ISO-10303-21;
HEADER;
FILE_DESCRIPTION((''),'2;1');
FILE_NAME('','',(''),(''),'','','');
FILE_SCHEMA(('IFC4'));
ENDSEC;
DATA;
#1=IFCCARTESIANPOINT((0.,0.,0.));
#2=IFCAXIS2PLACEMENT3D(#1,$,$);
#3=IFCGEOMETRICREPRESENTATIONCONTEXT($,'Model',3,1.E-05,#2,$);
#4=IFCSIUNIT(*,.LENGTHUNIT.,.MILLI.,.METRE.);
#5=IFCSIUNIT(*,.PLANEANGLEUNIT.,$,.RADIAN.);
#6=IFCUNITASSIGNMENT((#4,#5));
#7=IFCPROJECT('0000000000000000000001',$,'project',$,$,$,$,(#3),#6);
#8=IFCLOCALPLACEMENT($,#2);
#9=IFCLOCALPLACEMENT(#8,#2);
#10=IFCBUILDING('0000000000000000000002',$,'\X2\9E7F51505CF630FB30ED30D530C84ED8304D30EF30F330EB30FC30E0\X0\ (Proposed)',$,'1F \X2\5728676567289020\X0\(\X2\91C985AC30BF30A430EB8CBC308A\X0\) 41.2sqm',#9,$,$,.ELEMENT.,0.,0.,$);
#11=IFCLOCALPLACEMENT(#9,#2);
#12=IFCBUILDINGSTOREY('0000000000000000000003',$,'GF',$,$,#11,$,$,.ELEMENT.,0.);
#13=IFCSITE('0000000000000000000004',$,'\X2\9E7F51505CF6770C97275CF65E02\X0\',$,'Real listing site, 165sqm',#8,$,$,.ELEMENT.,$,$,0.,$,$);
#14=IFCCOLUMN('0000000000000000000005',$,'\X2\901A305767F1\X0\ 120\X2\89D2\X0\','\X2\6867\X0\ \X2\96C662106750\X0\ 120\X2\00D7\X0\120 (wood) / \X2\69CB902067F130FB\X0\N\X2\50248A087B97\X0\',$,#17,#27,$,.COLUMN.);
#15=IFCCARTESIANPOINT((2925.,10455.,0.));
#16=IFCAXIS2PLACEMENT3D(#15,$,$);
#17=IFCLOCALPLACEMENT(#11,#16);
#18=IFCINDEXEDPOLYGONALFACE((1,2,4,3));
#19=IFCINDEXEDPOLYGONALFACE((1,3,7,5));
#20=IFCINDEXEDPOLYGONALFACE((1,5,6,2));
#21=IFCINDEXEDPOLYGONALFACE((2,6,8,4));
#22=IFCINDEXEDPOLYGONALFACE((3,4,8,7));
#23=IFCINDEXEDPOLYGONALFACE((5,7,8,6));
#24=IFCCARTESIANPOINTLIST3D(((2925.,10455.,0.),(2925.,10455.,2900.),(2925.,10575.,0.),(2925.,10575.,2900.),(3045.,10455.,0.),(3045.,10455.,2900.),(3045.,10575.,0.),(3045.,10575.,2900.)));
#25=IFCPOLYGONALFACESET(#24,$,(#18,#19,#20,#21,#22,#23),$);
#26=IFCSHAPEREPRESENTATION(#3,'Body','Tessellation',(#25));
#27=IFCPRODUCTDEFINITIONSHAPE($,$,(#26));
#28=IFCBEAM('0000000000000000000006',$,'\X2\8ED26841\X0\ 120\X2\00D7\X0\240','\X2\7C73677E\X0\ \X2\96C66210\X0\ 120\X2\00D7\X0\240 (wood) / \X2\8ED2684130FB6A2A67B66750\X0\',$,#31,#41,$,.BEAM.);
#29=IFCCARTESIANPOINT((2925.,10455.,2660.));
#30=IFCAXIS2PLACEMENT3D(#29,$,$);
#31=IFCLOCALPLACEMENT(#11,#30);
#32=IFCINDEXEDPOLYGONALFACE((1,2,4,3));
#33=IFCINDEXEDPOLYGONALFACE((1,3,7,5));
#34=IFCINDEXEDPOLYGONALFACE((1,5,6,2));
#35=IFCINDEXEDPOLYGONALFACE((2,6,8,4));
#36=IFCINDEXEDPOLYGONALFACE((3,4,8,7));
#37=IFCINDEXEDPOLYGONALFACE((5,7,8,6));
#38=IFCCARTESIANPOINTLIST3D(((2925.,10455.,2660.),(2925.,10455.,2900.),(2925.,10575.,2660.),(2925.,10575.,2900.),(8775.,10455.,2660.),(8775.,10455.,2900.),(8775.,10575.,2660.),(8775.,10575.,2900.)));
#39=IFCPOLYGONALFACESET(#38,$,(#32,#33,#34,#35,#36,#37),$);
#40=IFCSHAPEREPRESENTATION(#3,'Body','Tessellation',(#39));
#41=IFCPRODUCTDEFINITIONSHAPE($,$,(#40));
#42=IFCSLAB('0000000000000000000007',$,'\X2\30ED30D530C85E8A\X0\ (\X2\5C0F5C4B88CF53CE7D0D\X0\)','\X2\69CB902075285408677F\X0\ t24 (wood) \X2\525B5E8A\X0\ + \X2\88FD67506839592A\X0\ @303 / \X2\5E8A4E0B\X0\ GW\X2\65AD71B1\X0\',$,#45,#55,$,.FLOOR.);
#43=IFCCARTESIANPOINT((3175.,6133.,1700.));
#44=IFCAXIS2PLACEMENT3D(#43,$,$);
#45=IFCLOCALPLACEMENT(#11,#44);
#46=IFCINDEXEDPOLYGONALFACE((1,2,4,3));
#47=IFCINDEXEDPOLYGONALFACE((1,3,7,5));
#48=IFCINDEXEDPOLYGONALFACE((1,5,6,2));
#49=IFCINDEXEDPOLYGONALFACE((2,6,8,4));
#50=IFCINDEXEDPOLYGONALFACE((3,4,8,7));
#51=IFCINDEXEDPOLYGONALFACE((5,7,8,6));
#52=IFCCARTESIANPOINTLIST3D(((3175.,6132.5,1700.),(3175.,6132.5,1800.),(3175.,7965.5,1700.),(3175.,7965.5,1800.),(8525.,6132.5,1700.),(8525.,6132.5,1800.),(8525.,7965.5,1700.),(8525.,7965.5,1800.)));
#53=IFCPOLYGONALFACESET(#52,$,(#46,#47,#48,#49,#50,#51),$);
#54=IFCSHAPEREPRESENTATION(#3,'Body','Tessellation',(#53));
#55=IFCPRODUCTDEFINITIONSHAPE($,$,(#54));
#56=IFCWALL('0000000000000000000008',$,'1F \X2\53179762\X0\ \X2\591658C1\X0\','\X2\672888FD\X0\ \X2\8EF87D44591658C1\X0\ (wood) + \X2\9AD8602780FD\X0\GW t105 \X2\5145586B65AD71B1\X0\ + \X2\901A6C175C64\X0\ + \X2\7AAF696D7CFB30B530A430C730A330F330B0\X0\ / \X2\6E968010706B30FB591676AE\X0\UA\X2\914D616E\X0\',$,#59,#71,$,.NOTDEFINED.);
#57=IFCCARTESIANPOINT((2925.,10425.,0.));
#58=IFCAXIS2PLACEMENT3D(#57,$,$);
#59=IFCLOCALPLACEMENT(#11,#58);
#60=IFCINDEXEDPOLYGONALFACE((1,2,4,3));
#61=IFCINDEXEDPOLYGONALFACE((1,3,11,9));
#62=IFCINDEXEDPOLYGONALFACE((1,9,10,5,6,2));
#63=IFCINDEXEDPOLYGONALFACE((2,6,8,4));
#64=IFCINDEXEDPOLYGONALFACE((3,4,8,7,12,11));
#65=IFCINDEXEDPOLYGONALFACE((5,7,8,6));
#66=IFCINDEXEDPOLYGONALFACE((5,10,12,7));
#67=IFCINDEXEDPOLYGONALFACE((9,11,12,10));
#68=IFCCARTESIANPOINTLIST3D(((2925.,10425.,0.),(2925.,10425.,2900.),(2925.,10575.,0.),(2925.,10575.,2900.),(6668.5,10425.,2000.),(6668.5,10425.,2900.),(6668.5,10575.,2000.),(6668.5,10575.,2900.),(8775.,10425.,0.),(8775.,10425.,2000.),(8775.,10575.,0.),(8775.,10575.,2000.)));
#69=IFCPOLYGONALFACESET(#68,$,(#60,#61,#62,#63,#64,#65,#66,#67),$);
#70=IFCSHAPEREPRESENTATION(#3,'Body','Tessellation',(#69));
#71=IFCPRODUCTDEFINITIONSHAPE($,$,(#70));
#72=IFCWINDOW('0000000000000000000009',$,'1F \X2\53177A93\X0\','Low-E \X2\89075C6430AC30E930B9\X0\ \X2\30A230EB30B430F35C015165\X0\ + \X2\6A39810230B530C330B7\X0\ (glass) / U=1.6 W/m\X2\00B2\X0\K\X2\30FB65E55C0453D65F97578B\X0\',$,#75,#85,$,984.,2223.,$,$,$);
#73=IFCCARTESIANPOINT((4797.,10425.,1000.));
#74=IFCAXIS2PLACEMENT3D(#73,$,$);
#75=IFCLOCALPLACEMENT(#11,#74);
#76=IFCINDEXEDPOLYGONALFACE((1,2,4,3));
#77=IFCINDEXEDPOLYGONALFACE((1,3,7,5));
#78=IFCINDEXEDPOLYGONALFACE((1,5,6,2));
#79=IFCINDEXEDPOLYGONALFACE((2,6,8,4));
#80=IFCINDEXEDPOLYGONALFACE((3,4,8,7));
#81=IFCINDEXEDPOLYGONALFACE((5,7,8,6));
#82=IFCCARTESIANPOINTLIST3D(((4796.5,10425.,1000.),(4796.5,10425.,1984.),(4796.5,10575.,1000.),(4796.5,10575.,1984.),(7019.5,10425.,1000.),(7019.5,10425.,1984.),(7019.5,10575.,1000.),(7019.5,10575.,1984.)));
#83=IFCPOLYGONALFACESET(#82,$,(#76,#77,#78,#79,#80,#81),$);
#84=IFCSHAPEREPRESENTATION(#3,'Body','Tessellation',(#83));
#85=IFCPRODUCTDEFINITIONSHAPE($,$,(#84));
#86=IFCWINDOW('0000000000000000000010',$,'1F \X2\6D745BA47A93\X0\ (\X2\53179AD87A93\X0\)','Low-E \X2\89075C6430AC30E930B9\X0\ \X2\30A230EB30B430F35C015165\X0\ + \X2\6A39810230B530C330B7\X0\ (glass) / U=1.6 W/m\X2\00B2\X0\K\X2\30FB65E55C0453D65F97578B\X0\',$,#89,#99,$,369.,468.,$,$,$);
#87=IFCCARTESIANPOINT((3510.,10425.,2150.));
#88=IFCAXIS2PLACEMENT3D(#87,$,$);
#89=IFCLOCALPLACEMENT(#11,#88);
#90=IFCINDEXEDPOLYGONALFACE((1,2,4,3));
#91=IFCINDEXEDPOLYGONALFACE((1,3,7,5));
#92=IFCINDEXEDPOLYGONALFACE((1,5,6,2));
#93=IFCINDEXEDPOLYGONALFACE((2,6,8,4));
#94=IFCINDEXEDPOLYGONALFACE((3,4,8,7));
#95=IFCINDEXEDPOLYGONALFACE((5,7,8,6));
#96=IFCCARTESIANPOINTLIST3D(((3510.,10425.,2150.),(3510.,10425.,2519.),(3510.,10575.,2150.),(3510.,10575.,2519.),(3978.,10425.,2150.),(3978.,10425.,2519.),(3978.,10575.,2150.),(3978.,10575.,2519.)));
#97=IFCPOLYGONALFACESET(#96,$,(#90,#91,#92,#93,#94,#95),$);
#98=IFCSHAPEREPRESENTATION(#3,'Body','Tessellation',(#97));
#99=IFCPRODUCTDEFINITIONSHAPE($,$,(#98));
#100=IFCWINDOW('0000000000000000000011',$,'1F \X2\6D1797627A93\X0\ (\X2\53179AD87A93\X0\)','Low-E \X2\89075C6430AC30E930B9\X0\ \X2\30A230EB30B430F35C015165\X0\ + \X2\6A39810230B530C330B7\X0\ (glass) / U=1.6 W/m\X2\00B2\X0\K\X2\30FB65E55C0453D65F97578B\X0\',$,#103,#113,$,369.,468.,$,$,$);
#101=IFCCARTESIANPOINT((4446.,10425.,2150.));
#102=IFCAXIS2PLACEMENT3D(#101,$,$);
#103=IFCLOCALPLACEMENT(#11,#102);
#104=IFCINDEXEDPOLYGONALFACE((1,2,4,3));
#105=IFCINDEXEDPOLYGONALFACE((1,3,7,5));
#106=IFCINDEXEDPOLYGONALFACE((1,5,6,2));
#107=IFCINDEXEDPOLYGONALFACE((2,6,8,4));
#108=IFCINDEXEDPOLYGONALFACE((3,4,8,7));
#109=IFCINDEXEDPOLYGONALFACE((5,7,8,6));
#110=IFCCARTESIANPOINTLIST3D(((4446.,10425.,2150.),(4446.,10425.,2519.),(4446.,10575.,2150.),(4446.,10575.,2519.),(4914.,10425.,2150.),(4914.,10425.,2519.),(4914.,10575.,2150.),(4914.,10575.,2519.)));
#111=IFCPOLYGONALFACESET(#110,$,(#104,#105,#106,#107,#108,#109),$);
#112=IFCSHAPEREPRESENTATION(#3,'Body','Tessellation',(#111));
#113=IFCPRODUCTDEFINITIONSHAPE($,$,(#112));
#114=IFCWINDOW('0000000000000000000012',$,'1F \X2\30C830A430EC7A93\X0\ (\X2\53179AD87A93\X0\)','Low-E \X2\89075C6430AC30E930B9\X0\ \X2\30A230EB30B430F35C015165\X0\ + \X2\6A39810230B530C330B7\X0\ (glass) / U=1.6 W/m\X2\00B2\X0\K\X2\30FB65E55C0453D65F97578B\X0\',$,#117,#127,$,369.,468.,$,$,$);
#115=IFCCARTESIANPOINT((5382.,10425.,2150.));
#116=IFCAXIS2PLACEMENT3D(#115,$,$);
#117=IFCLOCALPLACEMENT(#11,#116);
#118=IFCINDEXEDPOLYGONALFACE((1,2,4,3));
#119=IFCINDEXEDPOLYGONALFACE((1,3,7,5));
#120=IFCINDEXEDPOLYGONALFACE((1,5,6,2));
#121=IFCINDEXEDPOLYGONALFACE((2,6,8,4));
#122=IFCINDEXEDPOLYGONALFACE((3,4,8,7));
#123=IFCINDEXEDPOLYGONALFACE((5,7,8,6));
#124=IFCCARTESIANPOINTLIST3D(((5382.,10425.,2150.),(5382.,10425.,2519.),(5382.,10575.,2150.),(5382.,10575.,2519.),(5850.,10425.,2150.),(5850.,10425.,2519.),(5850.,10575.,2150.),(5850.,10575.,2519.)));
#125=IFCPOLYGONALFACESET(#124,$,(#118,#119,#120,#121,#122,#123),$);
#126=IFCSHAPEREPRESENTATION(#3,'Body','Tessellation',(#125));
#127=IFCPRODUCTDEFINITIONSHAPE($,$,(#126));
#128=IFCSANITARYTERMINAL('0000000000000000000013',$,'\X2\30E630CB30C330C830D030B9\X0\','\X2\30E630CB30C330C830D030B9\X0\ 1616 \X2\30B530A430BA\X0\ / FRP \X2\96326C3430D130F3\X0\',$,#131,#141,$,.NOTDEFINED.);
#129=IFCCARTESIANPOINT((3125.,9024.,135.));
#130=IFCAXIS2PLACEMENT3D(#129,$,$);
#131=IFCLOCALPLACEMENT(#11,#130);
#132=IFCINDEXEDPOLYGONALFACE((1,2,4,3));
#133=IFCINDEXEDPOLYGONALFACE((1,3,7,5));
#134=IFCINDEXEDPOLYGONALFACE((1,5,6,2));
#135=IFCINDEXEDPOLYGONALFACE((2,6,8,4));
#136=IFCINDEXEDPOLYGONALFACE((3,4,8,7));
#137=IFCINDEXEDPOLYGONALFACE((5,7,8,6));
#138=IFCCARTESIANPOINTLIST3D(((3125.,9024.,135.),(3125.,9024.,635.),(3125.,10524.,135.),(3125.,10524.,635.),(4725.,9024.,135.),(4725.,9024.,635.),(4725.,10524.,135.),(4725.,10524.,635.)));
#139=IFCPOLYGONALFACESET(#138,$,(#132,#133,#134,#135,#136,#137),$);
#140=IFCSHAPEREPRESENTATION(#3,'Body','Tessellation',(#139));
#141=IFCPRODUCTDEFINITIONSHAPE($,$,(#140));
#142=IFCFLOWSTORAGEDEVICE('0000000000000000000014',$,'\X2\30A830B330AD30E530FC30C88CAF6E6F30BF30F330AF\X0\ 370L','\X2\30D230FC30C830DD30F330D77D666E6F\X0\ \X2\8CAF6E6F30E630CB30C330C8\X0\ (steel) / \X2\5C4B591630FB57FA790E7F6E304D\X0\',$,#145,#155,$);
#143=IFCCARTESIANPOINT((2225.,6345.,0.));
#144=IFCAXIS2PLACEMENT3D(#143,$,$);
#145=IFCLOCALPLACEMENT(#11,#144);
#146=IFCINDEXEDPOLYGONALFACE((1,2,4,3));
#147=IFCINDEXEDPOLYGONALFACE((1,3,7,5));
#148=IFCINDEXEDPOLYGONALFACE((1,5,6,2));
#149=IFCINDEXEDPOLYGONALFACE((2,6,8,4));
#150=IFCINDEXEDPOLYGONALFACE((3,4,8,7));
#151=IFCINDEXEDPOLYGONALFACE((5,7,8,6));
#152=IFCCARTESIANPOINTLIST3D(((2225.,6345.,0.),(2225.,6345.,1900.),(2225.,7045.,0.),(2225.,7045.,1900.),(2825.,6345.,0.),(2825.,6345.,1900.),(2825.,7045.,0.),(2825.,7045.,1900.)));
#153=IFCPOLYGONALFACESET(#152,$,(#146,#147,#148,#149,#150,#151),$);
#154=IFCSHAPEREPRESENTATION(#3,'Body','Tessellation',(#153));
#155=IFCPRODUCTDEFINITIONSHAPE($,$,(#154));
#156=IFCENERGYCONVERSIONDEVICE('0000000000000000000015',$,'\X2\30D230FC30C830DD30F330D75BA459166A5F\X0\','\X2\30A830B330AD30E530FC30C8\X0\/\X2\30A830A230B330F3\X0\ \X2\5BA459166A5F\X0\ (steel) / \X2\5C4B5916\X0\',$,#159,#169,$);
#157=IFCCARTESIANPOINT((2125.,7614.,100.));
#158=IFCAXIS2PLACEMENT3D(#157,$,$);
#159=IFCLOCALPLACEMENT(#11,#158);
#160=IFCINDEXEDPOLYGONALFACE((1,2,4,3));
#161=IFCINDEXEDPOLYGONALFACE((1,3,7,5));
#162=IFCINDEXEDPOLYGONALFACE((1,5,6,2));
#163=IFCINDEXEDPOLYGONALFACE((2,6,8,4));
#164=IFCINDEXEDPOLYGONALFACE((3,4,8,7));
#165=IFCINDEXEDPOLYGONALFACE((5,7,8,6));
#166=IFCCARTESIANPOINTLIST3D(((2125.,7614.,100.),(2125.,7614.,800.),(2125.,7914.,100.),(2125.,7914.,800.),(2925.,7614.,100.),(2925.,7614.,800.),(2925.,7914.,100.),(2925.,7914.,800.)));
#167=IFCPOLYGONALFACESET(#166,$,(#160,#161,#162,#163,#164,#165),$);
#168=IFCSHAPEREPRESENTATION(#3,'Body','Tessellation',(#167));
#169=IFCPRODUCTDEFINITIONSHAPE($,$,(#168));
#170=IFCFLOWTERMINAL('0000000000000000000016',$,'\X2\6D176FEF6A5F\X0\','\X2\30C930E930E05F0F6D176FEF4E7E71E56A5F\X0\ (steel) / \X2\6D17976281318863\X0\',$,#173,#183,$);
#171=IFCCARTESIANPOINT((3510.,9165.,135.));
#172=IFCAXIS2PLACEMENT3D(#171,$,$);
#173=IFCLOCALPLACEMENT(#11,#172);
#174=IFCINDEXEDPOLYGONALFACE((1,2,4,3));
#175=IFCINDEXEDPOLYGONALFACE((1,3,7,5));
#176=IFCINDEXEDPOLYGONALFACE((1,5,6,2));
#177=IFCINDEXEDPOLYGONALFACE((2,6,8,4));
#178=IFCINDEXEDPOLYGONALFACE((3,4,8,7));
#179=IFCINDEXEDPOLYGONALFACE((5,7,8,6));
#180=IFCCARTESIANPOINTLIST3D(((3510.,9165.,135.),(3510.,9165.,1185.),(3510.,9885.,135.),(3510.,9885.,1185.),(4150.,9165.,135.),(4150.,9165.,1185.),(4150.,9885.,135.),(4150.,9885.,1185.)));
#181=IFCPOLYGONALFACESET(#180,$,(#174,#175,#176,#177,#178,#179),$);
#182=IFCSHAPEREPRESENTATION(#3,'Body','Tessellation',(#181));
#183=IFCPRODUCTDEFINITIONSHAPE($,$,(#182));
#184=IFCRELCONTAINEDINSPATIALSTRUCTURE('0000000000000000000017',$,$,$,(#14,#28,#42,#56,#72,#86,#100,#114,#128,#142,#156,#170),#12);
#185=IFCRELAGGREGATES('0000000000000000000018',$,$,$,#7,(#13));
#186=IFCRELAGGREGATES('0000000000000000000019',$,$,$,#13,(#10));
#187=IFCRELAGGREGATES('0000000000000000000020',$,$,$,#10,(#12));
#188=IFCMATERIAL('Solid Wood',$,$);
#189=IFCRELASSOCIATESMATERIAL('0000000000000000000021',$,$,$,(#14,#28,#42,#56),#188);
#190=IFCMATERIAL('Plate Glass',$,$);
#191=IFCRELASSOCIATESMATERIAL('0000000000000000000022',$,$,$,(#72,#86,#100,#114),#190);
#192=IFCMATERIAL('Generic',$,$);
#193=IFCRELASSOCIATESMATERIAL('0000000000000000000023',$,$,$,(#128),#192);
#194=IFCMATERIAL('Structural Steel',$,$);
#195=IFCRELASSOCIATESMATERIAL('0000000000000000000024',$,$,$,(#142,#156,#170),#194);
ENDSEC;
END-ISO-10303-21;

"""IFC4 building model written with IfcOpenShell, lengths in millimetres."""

from ifc_helpers import new_model, si_unit, frame, frame_2d, origin, place, context, project, spatial, rectangle, extrude, material, element, fill, save


model = new_model("IFC4")

# Units and contexts
model_context = context("Model", 3, precision=1e-05, world=origin())
ifc_project = project(units=[si_unit("LENGTHUNIT", "METRE", prefix="MILLI"), si_unit("PLANEANGLEUNIT", "RADIAN")], contexts=[model_context])

# Site, building, storey
site_placement = place(None, origin())
site = spatial("IfcSite", under=ifc_project, at=site_placement, Name="鹿児島県霧島市", ObjectType="Real listing site, 165sqm", CompositionType="ELEMENT", RefElevation=0.0)
building_placement = place(site_placement, origin())
building = spatial("IfcBuilding", under=site, at=building_placement, Name="鹿児島・ロフト付きワンルーム (Proposed)", ObjectType="1F 在来木造(釉薬タイル貼り) 41.2sqm", CompositionType="ELEMENT", ElevationOfRefHeight=0.0, ElevationOfTerrain=0.0)
storey_placement = place(building_placement, origin())
storey = spatial("IfcBuildingStorey", under=building, at=storey_placement, Name="GF", CompositionType="ELEMENT", Elevation=0.0)

# Column
ifc_material_1 = material(Name="Solid Wood")
column_1_placement = place(storey_placement, frame((2925.0, 10455.0, 0.0)))
element("IfcColumn", 1, at=column_1_placement, inside=storey, material=ifc_material_1, Name="通し柱 120角", Description="桧 集成材 120×120 (wood) / 構造柱・N値計算", PredefinedType="COLUMN", context=model_context, shape_type="SweptSolid", body=[
    extrude(rectangle(XDim=120.0, YDim=120.0, at=frame_2d((60.0, 60.0))), frame((2925.0, 10455.0, 0.0)), (0.0, 0.0, 1.0), 2900.0),
])

# Beam
beam_1_placement = place(storey_placement, frame((2925.0, 10455.0, 2660.0)))
element("IfcBeam", 2, at=beam_1_placement, inside=storey, material=ifc_material_1, Name="軒桁 120×240", Description="米松 集成 120×240 (wood) / 軒桁・横架材", PredefinedType="BEAM", context=model_context, shape_type="SweptSolid", body=[
    extrude(rectangle(XDim=5850.0, YDim=120.0, at=frame_2d((2925.0, 60.0))), frame((2925.0, 10455.0, 2660.0)), (0.0, 0.0, 1.0), 240.0),
])

# Slab
slab_placement = place(storey_placement, frame((3175.0, 6133.0, 1700.0)))
element("IfcSlab", 3, at=slab_placement, inside=storey, material=ifc_material_1, Name="ロフト床 (小屋裏収納)", Description="構造用合板 t24 (wood) 剛床 + 製材根太 @303 / 床下 GW断熱", PredefinedType="FLOOR", context=model_context, shape_type="SweptSolid", body=[
    extrude(rectangle(XDim=5350.0, YDim=1833.0, at=frame_2d((2675.0, 916.0))), frame((3175.0, 6133.0, 1700.0)), (0.0, 0.0, 1.0), 100.0),
])

# Wall, openings, windows
wall_1_placement = place(storey_placement, frame((2925.0, 10425.0, 0.0)))
wall_1 = element("IfcWall", 4, at=wall_1_placement, inside=storey, material=ifc_material_1, Name="1F 北面 外壁", Description="木製 軸組外壁 (wood) + 高性能GW t105 充填断熱 + 通気層 + 窯業系サイディング / 準耐火・外皮UA配慮", PredefinedType="NOTDEFINED", context=model_context, shape_type="SweptSolid", body=[
    extrude(rectangle(XDim=5850.0, YDim=150.0, at=frame_2d((2925.0, 75.0))), frame((2925.0, 10425.0, 0.0)), (0.0, 0.0, 1.0), 2900.0),
])
opening_1_placement = place(storey_placement, frame((4797.0, 10425.0, 1000.0)))
opening_1 = element("IfcOpeningElement", 5, at=opening_1_placement, cuts=wall_1, PredefinedType="NOTDEFINED", context=model_context, shape_type="SweptSolid", body=[
    extrude(rectangle(XDim=2223.0, YDim=150.0, at=frame_2d((1111.0, 75.0))), frame((4797.0, 10425.0, 1000.0)), (0.0, 0.0, 1.0), 984.0),
])
opening_2_placement = place(storey_placement, frame((3510.0, 10425.0, 2150.0)))
opening_2 = element("IfcOpeningElement", 6, at=opening_2_placement, cuts=wall_1, PredefinedType="NOTDEFINED", context=model_context, shape_type="SweptSolid", body=[
    extrude(rectangle(XDim=468.0, YDim=150.0, at=frame_2d((234.0, 75.0))), frame((3510.0, 10425.0, 2150.0)), (0.0, 0.0, 1.0), 369.0),
])
opening_3_placement = place(storey_placement, frame((4446.0, 10425.0, 2150.0)))
opening_3 = element("IfcOpeningElement", 7, at=opening_3_placement, cuts=wall_1, PredefinedType="NOTDEFINED", context=model_context, shape_type="SweptSolid", body=[
    extrude(rectangle(XDim=468.0, YDim=150.0, at=frame_2d((234.0, 75.0))), frame((4446.0, 10425.0, 2150.0)), (0.0, 0.0, 1.0), 369.0),
])
opening_4_placement = place(storey_placement, frame((5382.0, 10425.0, 2150.0)))
opening_4 = element("IfcOpeningElement", 8, at=opening_4_placement, cuts=wall_1, PredefinedType="NOTDEFINED", context=model_context, shape_type="SweptSolid", body=[
    extrude(rectangle(XDim=468.0, YDim=150.0, at=frame_2d((234.0, 75.0))), frame((5382.0, 10425.0, 2150.0)), (0.0, 0.0, 1.0), 369.0),
])
ifc_material_2 = material(Name="Plate Glass")
window_1_placement = place(storey_placement, frame((4797.0, 10425.0, 1000.0)))
window_1 = element("IfcWindow", 9, at=window_1_placement, inside=storey, material=ifc_material_2, Name="1F 北窓", Description="Low-E 複層ガラス アルゴン封入 + 樹脂サッシ (glass) / U=1.6 W/m²K・日射取得型", OverallHeight=984.0, OverallWidth=2223.0, context=model_context, shape_type="SweptSolid", body=[
    extrude(rectangle(XDim=2223.0, YDim=150.0, at=frame_2d((1111.0, 75.0))), frame((4797.0, 10425.0, 1000.0)), (0.0, 0.0, 1.0), 984.0),
])
fill(opening_1, window_1)
window_2_placement = place(storey_placement, frame((3510.0, 10425.0, 2150.0)))
window_2 = element("IfcWindow", 10, at=window_2_placement, inside=storey, material=ifc_material_2, Name="1F 浴室窓 (北高窓)", Description="Low-E 複層ガラス アルゴン封入 + 樹脂サッシ (glass) / U=1.6 W/m²K・日射取得型", OverallHeight=369.0, OverallWidth=468.0, context=model_context, shape_type="SweptSolid", body=[
    extrude(rectangle(XDim=468.0, YDim=150.0, at=frame_2d((234.0, 75.0))), frame((3510.0, 10425.0, 2150.0)), (0.0, 0.0, 1.0), 369.0),
])
fill(opening_2, window_2)
window_3_placement = place(storey_placement, frame((4446.0, 10425.0, 2150.0)))
window_3 = element("IfcWindow", 11, at=window_3_placement, inside=storey, material=ifc_material_2, Name="1F 洗面窓 (北高窓)", Description="Low-E 複層ガラス アルゴン封入 + 樹脂サッシ (glass) / U=1.6 W/m²K・日射取得型", OverallHeight=369.0, OverallWidth=468.0, context=model_context, shape_type="SweptSolid", body=[
    extrude(rectangle(XDim=468.0, YDim=150.0, at=frame_2d((234.0, 75.0))), frame((4446.0, 10425.0, 2150.0)), (0.0, 0.0, 1.0), 369.0),
])
fill(opening_3, window_3)
window_4_placement = place(storey_placement, frame((5382.0, 10425.0, 2150.0)))
window_4 = element("IfcWindow", 12, at=window_4_placement, inside=storey, material=ifc_material_2, Name="1F トイレ窓 (北高窓)", Description="Low-E 複層ガラス アルゴン封入 + 樹脂サッシ (glass) / U=1.6 W/m²K・日射取得型", OverallHeight=369.0, OverallWidth=468.0, context=model_context, shape_type="SweptSolid", body=[
    extrude(rectangle(XDim=468.0, YDim=150.0, at=frame_2d((234.0, 75.0))), frame((5382.0, 10425.0, 2150.0)), (0.0, 0.0, 1.0), 369.0),
])
fill(opening_4, window_4)

# Sanitary terminal
ifc_material_3 = material(Name="Generic")
sanitary_terminal_placement = place(storey_placement, frame((3125.0, 9024.0, 135.0)))
element("IfcSanitaryTerminal", 13, at=sanitary_terminal_placement, inside=storey, material=ifc_material_3, Name="ユニットバス", Description="ユニットバス 1616 サイズ / FRP 防水パン", PredefinedType="NOTDEFINED", context=model_context, shape_type="SweptSolid", body=[
    extrude(rectangle(XDim=1600.0, YDim=1500.0, at=frame_2d((800.0, 750.0))), frame((3125.0, 9024.0, 135.0)), (0.0, 0.0, 1.0), 500.0),
])

# Flow storage device
ifc_material_4 = material(Name="Structural Steel")
flow_storage_device_placement = place(storey_placement, frame((2225.0, 6345.0, 0.0)))
element("IfcFlowStorageDevice", 14, at=flow_storage_device_placement, inside=storey, material=ifc_material_4, Name="エコキュート貯湯タンク 370L", Description="ヒートポンプ給湯 貯湯ユニット (steel) / 屋外・基礎置き", context=model_context, shape_type="SweptSolid", body=[
    extrude(rectangle(XDim=600.0, YDim=700.0, at=frame_2d((300.0, 350.0))), frame((2225.0, 6345.0, 0.0)), (0.0, 0.0, 1.0), 1900.0),
])

# Energy conversion device
energy_conversion_device_placement = place(storey_placement, frame((2125.0, 7614.0, 100.0)))
element("IfcEnergyConversionDevice", 15, at=energy_conversion_device_placement, inside=storey, material=ifc_material_4, Name="ヒートポンプ室外機", Description="エコキュート/エアコン 室外機 (steel) / 屋外", context=model_context, shape_type="SweptSolid", body=[
    extrude(rectangle(XDim=800.0, YDim=300.0, at=frame_2d((400.0, 150.0))), frame((2125.0, 7614.0, 100.0)), (0.0, 0.0, 1.0), 700.0),
])

# Flow terminal
flow_terminal_placement = place(storey_placement, frame((3510.0, 9165.0, 135.0)))
element("IfcFlowTerminal", 16, at=flow_terminal_placement, inside=storey, material=ifc_material_4, Name="洗濯機", Description="ドラム式洗濯乾燥機 (steel) / 洗面脱衣", context=model_context, shape_type="SweptSolid", body=[
    extrude(rectangle(XDim=640.0, YDim=720.0, at=frame_2d((320.0, 360.0))), frame((3510.0, 9165.0, 135.0)), (0.0, 0.0, 1.0), 1050.0),
])

save(model, "model.ifc")
